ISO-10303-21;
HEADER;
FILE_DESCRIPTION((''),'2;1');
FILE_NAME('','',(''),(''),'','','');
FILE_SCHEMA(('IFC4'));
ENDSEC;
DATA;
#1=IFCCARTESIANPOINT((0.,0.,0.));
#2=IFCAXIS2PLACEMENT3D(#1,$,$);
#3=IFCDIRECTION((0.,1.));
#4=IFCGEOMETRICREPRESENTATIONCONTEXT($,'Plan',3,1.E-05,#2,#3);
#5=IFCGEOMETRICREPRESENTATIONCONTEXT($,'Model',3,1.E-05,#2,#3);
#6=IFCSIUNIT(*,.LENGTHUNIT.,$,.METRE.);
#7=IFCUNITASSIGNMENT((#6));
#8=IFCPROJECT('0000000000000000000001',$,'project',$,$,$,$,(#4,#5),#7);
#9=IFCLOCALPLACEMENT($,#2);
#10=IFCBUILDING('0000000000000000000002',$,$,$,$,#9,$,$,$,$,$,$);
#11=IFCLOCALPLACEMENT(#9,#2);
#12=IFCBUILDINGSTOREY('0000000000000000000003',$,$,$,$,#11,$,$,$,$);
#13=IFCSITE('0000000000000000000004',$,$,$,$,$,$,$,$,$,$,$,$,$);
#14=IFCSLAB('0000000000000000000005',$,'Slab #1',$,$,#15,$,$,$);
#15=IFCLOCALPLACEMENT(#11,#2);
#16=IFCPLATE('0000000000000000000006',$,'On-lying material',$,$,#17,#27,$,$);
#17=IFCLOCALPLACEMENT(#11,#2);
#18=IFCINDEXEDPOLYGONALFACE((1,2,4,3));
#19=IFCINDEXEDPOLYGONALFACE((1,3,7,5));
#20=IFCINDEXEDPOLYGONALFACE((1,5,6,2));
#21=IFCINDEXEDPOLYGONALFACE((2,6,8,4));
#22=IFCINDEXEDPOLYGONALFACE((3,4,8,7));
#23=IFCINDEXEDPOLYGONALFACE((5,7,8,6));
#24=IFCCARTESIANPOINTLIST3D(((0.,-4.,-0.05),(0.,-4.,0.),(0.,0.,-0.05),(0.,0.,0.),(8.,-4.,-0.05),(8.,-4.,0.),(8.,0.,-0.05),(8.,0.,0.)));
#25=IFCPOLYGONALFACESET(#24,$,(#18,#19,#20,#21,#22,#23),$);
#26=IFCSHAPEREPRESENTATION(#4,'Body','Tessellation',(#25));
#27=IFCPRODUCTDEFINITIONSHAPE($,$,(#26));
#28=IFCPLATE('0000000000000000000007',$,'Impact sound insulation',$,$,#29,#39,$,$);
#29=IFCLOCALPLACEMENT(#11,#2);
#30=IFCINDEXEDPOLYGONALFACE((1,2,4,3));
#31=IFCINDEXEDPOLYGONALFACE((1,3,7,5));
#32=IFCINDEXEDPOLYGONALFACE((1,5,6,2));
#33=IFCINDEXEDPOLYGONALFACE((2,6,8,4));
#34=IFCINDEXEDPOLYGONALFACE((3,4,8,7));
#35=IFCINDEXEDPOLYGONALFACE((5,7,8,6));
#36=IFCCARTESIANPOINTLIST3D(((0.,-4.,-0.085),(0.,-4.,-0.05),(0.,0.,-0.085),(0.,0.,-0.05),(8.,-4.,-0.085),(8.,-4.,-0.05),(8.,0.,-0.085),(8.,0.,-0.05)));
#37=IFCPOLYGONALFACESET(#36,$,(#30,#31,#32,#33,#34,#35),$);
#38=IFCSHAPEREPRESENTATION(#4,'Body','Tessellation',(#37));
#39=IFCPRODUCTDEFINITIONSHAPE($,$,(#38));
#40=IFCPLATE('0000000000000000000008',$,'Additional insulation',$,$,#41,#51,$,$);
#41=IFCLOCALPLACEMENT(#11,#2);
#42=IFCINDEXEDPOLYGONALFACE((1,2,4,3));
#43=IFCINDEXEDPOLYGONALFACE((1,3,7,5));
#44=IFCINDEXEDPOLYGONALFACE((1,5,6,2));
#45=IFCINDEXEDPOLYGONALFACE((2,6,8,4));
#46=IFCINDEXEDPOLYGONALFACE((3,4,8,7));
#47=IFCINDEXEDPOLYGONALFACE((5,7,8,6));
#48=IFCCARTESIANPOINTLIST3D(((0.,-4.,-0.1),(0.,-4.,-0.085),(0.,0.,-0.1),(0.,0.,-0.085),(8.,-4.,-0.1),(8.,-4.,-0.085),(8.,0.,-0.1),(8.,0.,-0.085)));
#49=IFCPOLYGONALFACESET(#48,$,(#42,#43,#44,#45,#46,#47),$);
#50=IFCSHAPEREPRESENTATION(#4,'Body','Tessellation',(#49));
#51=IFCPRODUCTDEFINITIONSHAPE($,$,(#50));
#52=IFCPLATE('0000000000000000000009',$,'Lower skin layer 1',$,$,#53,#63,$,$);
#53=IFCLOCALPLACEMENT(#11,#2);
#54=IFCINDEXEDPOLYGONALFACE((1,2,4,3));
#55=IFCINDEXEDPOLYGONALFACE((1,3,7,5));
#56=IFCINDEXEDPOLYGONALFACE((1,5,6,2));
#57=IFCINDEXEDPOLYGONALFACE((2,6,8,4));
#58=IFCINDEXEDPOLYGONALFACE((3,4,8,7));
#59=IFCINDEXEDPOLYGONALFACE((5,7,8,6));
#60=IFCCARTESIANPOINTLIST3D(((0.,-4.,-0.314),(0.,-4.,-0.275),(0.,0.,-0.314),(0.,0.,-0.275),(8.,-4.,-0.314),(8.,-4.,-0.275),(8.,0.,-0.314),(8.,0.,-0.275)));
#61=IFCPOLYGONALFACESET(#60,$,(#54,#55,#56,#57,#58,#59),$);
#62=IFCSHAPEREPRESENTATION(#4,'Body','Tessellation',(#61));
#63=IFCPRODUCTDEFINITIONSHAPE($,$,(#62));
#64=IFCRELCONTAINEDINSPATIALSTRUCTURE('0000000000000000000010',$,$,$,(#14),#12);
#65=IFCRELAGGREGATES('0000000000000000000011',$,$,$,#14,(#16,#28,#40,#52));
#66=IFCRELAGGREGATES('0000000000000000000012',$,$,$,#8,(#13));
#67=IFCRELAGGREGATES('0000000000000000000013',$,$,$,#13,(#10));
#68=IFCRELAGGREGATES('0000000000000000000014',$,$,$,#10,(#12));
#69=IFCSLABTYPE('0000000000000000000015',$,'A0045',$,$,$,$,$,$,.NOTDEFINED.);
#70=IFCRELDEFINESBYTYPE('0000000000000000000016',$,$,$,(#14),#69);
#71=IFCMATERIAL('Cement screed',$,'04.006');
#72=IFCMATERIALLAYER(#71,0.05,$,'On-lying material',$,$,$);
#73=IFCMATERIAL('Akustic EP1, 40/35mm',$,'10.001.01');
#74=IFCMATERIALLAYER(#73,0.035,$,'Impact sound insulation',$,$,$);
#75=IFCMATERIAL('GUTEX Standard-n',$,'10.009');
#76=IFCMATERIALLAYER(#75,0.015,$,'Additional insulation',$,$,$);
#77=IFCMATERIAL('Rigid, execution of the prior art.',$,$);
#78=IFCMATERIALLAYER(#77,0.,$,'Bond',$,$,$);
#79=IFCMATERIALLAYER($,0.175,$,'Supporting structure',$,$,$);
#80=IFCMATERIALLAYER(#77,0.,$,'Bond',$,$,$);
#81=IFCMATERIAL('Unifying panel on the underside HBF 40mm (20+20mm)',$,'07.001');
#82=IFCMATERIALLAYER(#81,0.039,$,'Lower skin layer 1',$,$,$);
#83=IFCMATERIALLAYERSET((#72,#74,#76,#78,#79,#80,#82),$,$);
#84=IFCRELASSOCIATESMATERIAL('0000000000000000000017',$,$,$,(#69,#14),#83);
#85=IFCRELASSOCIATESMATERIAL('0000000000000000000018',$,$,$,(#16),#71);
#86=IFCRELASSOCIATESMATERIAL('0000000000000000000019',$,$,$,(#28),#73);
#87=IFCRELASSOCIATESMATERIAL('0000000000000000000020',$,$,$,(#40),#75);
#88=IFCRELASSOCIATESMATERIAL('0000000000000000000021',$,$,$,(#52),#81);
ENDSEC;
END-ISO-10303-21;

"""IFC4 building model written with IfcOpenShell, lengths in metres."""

from ifc_helpers import new_model, si_unit, direction, frame, frame_2d, origin, origin_with_axes, place, context, project, spatial, rectangle, extrude, material, layer, layer_set, type_object, element, aggregate, save


model = new_model("IFC4")

# Units and contexts
plan_context = context("Plan", 3, precision=1e-05, world=origin(), true_north=direction((0.0, 1.0)))
model_context = context("Model", 3, precision=1e-05, world=origin(), true_north=direction((0.0, 1.0)))
ifc_project = project(units=[si_unit("LENGTHUNIT", "METRE")], contexts=[plan_context, model_context])

# Site, building, storey
site = spatial("IfcSite", under=ifc_project)
building_placement = place(None, origin())
building = spatial("IfcBuilding", under=site, at=building_placement)
storey_placement = place(building_placement, origin())
storey = spatial("IfcBuildingStorey", under=building, at=storey_placement)

# Slab, plates
ifc_material_1 = material(Name="Cement screed", Category="04.006")
ifc_layer_1 = layer(ifc_material_1, 0.05, Name="On-lying material")
ifc_material_2 = material(Name="Akustic EP1, 40/35mm", Category="10.001.01")
ifc_layer_2 = layer(ifc_material_2, 0.035, Name="Impact sound insulation")
ifc_material_3 = material(Name="GUTEX Standard-n", Category="10.009")
ifc_layer_3 = layer(ifc_material_3, 0.015, Name="Additional insulation")
ifc_material_4 = material(Name="Rigid, execution of the prior art.")
ifc_layer_4 = layer(ifc_material_4, 0.0, Name="Bond")
ifc_layer_5 = layer(None, 0.175, Name="Supporting structure")
ifc_layer_6 = layer(ifc_material_4, 0.0, Name="Bond")
ifc_material_5 = material(Name="Unifying panel on the underside HBF 40mm (20+20mm)", Category="07.001")
ifc_layer_7 = layer(ifc_material_5, 0.039, Name="Lower skin layer 1")
ifc_layer_set = layer_set([ifc_layer_1, ifc_layer_2, ifc_layer_3, ifc_layer_4, ifc_layer_5, ifc_layer_6, ifc_layer_7])
slab_type = type_object("IfcSlabType", Name="A0045", PredefinedType="NOTDEFINED", material=ifc_layer_set)
slab_placement = place(None, frame((0.0, 0.0, 0.0), z_axis=(0.0, 0.0, -1.0), x_axis=(1.0, 0.0, 0.0)))
slab = element("IfcSlab", 1, at=slab_placement, inside=storey, type_object=slab_type, material=ifc_layer_set, Name="Slab #1")
plate_1_placement = place(slab_placement, origin())
plate_1 = element("IfcPlate", 2, at=plate_1_placement, material=ifc_material_1, Name="On-lying material", context=plan_context, shape_type="SweptSolid", body=[
    extrude(rectangle(XDim=8.0, YDim=4.0, at=frame_2d((4.0, 2.0), x_axis=(1.0, 0.0))), origin_with_axes(), (0.0, 0.0, 1.0), 0.05),
])
plate_2_placement = place(slab_placement, origin())
plate_2 = element("IfcPlate", 3, at=plate_2_placement, material=ifc_material_2, Name="Impact sound insulation", context=plan_context, shape_type="SweptSolid", body=[
    extrude(rectangle(XDim=8.0, YDim=4.0, at=frame_2d((4.0, 2.0), x_axis=(1.0, 0.0))), frame((0.0, 0.0, 0.05), z_axis=(0.0, 0.0, 1.0), x_axis=(1.0, 0.0, 0.0)), (0.0, 0.0, 1.0), 0.035),
])
plate_3_placement = place(slab_placement, origin())
plate_3 = element("IfcPlate", 4, at=plate_3_placement, material=ifc_material_3, Name="Additional insulation", context=plan_context, shape_type="SweptSolid", body=[
    extrude(rectangle(XDim=8.0, YDim=4.0, at=frame_2d((4.0, 2.0), x_axis=(1.0, 0.0))), frame((0.0, 0.0, 0.085), z_axis=(0.0, 0.0, 1.0), x_axis=(1.0, 0.0, 0.0)), (0.0, 0.0, 1.0), 0.015),
])
plate_4_placement = place(slab_placement, origin())
plate_4 = element("IfcPlate", 5, at=plate_4_placement, material=ifc_material_5, Name="Lower skin layer 1", context=plan_context, shape_type="SweptSolid", body=[
    extrude(rectangle(XDim=8.0, YDim=4.0, at=frame_2d((4.0, 2.0), x_axis=(1.0, 0.0))), frame((0.0, 0.0, 0.275), z_axis=(0.0, 0.0, 1.0), x_axis=(1.0, 0.0, 0.0)), (0.0, 0.0, 1.0), 0.039),
])
aggregate(slab, [plate_1, plate_2, plate_3, plate_4])

save(model, "model.ifc")
